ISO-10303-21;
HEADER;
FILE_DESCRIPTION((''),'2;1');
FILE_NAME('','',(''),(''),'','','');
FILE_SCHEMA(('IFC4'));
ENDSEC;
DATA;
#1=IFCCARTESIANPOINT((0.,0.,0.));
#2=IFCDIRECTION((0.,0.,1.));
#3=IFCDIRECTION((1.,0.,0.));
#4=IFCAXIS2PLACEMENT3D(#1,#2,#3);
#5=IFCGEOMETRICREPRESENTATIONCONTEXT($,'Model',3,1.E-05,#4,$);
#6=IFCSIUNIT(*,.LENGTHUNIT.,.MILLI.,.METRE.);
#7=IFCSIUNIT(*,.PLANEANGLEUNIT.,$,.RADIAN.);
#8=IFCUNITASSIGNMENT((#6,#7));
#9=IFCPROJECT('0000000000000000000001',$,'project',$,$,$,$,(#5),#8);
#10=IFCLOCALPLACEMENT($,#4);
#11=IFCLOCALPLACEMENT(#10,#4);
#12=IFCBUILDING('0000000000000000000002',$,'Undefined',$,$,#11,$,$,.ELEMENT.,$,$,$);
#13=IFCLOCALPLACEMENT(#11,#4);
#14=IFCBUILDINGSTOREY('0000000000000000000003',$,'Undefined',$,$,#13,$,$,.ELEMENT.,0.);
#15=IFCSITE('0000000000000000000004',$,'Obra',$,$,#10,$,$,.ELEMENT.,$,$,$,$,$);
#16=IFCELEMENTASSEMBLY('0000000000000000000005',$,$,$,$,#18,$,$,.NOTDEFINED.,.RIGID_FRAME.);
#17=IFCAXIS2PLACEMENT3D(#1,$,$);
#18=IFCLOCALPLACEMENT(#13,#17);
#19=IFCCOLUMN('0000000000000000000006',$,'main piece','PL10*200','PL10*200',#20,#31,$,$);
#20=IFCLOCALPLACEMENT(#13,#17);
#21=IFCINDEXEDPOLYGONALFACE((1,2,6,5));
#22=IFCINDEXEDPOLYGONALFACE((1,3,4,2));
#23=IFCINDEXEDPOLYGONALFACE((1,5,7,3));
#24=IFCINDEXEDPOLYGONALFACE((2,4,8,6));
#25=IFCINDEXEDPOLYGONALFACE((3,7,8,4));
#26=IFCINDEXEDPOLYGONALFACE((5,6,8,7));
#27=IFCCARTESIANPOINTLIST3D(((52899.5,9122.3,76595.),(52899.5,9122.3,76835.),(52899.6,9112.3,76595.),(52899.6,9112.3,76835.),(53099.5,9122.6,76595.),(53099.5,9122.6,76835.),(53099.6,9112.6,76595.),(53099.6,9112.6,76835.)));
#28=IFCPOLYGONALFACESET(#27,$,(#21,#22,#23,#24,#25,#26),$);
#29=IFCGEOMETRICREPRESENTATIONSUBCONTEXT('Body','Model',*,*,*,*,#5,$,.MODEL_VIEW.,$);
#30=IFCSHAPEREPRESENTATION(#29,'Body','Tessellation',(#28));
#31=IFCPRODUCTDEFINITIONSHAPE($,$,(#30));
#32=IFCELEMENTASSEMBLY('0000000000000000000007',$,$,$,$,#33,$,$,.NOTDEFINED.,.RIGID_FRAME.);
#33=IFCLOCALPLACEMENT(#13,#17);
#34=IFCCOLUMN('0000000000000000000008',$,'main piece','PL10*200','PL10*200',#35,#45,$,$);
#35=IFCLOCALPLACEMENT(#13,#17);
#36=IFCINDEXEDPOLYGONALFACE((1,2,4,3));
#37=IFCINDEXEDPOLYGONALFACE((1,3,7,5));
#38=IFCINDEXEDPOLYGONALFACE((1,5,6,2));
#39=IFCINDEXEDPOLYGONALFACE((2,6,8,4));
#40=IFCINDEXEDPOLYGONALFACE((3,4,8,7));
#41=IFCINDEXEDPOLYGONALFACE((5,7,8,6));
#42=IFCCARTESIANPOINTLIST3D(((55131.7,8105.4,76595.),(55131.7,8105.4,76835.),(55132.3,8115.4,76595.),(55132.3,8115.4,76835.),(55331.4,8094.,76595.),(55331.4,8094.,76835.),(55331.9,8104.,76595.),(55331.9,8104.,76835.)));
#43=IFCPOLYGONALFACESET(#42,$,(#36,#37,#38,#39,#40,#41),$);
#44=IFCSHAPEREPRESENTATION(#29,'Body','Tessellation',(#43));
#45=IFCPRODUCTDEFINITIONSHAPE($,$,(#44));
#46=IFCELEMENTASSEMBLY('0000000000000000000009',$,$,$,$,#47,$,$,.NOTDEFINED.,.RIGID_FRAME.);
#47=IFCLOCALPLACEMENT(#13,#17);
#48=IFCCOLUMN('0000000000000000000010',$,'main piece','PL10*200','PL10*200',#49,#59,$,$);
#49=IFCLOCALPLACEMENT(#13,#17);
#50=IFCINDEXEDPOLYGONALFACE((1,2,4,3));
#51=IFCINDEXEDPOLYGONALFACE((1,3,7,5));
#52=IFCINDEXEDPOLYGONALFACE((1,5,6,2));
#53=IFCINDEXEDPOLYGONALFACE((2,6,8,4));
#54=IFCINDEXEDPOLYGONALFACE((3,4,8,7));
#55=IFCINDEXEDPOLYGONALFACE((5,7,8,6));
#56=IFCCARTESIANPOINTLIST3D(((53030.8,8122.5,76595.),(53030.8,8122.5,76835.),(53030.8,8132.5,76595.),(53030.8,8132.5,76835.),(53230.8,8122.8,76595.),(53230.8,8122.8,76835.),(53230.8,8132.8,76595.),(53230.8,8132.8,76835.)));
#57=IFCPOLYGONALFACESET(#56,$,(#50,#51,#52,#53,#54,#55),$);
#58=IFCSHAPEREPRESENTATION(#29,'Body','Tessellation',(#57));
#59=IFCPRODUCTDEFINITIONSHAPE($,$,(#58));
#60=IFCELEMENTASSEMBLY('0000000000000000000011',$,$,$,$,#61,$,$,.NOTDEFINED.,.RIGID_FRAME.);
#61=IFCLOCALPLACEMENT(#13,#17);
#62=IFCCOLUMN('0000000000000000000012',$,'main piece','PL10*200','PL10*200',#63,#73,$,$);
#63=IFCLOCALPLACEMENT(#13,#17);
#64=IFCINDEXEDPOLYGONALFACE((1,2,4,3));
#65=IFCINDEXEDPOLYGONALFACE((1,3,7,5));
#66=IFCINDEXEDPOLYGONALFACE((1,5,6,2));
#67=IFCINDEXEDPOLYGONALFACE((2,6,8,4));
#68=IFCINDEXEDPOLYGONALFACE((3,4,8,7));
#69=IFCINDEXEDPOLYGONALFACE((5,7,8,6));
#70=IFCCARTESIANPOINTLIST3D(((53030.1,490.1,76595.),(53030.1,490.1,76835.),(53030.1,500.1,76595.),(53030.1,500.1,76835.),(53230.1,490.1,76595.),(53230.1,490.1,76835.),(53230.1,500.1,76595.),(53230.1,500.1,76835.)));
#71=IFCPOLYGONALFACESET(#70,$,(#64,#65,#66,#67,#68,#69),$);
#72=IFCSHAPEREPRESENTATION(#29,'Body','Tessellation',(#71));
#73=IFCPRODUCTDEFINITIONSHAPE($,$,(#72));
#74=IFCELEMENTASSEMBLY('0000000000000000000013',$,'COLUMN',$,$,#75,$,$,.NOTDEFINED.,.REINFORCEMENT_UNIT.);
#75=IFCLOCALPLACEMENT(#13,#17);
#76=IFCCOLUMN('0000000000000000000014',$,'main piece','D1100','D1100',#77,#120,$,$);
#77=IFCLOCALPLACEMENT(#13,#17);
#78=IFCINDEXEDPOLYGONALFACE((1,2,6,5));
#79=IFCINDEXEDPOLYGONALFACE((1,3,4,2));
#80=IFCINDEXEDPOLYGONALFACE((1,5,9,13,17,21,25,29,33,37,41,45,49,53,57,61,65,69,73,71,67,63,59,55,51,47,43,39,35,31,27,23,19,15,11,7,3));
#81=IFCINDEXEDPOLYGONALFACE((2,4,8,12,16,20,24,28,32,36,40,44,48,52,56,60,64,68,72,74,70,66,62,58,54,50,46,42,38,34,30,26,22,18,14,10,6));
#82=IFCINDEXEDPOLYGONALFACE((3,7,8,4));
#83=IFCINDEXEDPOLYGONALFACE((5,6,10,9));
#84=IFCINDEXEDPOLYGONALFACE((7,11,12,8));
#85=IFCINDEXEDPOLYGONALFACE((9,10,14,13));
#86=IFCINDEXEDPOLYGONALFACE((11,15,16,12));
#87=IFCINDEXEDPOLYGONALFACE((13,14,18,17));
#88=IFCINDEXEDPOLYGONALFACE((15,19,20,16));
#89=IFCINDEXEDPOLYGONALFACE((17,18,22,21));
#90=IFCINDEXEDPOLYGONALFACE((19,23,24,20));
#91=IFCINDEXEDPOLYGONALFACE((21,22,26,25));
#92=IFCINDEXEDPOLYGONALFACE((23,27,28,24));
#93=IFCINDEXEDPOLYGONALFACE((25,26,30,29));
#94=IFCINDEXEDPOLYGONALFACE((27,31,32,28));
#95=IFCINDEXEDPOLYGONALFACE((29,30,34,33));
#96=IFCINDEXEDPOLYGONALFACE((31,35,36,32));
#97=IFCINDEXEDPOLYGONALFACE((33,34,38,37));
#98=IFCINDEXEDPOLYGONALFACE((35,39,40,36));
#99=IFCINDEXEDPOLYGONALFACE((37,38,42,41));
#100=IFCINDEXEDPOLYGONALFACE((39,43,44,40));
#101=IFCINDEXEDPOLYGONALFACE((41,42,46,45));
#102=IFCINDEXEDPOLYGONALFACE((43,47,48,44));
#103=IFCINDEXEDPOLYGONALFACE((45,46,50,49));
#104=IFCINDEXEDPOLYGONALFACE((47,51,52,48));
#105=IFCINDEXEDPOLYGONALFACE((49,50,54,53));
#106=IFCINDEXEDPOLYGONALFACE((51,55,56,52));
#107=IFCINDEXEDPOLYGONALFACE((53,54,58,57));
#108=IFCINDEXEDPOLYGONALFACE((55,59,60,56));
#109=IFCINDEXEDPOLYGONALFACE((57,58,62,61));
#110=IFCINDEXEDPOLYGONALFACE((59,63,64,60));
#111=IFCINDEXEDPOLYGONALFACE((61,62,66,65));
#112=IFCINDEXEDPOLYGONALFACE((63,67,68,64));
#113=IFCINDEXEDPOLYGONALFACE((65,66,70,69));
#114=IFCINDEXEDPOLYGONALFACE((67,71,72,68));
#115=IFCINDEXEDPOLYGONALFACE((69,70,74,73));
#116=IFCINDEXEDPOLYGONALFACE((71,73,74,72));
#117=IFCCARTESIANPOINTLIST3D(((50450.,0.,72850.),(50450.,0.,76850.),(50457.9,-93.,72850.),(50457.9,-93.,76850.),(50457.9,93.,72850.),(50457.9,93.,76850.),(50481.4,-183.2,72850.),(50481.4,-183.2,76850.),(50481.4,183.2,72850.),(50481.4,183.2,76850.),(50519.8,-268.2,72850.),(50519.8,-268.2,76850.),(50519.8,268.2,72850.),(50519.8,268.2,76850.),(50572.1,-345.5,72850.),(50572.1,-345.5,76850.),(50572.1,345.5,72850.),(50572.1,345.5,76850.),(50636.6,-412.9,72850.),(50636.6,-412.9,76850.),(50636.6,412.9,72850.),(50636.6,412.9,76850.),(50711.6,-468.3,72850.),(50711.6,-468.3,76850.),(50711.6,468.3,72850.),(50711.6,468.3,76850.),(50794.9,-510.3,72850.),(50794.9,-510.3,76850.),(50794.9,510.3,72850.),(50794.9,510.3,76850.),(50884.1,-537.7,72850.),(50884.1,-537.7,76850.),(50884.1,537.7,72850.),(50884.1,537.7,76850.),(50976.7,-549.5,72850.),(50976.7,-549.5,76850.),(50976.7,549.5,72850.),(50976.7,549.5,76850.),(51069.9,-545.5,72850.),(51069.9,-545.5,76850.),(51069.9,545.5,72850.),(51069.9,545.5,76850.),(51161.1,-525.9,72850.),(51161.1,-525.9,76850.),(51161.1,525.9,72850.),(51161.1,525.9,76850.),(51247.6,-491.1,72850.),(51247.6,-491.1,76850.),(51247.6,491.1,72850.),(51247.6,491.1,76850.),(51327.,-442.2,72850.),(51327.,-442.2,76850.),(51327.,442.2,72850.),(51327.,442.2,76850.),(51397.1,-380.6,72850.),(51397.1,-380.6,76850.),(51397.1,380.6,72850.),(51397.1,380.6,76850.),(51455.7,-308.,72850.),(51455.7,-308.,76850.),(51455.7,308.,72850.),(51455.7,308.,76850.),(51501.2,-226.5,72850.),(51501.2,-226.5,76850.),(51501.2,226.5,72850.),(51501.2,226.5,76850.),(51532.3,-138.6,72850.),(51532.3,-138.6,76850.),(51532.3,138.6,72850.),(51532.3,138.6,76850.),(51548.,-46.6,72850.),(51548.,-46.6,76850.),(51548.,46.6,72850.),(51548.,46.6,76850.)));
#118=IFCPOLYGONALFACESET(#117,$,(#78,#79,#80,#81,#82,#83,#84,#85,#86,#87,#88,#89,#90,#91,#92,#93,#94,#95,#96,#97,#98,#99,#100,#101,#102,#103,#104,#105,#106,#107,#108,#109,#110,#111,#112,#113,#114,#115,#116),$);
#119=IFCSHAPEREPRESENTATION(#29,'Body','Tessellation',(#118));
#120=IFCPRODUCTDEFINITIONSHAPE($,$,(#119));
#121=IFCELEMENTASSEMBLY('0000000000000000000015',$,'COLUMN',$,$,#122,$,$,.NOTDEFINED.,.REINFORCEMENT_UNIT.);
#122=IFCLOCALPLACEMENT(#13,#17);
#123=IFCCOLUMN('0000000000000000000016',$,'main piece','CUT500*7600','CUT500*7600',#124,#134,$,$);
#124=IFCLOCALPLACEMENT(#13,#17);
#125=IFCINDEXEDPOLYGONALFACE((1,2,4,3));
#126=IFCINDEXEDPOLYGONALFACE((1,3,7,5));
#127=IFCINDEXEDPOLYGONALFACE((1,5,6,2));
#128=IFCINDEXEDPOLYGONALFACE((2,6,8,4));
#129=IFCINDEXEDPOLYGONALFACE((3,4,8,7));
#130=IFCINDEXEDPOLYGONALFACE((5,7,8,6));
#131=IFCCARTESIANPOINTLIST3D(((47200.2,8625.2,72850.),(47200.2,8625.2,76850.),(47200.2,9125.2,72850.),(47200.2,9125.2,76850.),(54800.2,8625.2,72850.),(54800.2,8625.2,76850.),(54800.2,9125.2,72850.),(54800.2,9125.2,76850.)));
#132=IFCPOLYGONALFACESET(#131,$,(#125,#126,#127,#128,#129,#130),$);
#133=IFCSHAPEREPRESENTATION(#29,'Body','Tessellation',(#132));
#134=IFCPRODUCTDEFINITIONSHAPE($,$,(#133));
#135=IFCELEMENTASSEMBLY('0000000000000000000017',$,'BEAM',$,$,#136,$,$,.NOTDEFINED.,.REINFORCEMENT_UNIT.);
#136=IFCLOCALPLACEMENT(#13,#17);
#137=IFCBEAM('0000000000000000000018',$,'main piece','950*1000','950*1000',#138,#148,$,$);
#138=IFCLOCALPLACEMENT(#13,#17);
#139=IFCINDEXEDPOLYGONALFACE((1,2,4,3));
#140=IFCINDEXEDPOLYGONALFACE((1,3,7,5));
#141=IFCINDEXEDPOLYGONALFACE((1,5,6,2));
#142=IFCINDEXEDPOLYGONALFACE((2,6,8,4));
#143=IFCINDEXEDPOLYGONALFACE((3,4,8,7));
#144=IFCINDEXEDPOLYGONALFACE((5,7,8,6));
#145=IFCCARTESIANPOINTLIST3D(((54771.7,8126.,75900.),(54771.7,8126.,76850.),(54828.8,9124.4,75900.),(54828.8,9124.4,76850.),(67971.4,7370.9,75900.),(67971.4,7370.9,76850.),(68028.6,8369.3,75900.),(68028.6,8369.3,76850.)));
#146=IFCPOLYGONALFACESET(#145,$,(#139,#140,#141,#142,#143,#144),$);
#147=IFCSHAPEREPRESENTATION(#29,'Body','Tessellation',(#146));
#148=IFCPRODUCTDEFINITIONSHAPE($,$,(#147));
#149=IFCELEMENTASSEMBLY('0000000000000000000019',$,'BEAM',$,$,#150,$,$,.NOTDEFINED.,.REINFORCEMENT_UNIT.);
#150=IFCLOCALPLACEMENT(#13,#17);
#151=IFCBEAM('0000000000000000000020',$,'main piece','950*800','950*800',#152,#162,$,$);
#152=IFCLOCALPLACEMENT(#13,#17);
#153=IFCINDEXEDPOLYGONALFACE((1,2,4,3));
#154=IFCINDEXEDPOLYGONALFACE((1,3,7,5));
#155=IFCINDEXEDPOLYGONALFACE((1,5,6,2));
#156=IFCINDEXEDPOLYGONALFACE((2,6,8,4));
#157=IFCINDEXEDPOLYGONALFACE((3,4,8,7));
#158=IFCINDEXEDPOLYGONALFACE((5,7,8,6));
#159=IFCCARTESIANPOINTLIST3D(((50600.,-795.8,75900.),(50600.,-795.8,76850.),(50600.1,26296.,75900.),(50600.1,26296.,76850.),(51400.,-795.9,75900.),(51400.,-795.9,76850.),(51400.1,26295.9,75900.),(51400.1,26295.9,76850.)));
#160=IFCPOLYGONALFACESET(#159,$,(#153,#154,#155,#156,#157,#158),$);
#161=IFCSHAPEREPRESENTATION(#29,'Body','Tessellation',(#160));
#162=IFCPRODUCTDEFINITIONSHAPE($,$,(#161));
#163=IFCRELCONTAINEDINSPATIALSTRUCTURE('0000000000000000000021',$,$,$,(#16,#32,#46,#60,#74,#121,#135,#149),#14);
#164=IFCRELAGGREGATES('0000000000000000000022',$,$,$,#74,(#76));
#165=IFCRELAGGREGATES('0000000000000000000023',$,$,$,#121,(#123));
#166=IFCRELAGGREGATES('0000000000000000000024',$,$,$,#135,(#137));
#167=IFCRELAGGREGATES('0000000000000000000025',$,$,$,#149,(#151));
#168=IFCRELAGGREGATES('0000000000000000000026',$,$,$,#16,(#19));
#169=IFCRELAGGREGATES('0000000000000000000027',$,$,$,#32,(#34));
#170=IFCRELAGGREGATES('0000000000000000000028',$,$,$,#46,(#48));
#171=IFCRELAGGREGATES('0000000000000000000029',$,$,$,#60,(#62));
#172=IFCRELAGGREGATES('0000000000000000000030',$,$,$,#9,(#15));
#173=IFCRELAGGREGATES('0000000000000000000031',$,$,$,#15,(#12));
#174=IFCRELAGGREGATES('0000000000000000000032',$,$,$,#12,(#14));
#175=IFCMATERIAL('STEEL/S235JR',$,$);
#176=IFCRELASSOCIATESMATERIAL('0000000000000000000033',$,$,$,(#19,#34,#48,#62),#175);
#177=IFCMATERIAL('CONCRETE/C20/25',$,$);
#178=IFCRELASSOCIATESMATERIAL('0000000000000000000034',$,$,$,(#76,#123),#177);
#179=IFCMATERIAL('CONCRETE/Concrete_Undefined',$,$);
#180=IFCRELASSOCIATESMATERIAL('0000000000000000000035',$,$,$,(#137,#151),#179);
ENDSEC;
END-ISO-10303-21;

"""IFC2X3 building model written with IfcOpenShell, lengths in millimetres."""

from ifc_helpers import new_model, si_unit, frame, origin_with_axes, origin_2d_with_axis, place, context, subcontext, project, spatial, rectangle, circle, extrude, material, element, aggregate, save


model = new_model("IFC2X3")

# Units and contexts
model_context = context("Model", 3, precision=1e-05, world=origin_with_axes())
body_context = subcontext(model_context, "Body", "Model", "MODEL_VIEW")
ifc_project = project(units=[si_unit("LENGTHUNIT", "METRE", prefix="MILLI"), si_unit("PLANEANGLEUNIT", "RADIAN")], contexts=[model_context])

# Site, building, storey
site_placement = place(None, origin_with_axes())
site = spatial("IfcSite", under=ifc_project, at=site_placement, Name="Obra", CompositionType="ELEMENT")
building_placement = place(site_placement, origin_with_axes())
building = spatial("IfcBuilding", under=site, at=building_placement, Name="Undefined", CompositionType="ELEMENT")
storey_placement = place(building_placement, origin_with_axes())
storey = spatial("IfcBuildingStorey", under=building, at=storey_placement, Name="Undefined", CompositionType="ELEMENT", Elevation=0.0)

# Element assemblies, columns
assembly_1_placement = place(storey_placement, origin_with_axes())
assembly_1 = element("IfcElementAssembly", 1, at=assembly_1_placement, inside=storey, AssemblyPlace="NOTDEFINED", PredefinedType="RIGID_FRAME")
ifc_material_1 = material(Name="STEEL/S235JR")
column_1_placement = place(assembly_1_placement, frame((52999.6, 9117.5, 76595.0), z_axis=(0.0, 0.0, 1.0), x_axis=(0.999999, 0.001508, 0.0)))
column_1 = element("IfcColumn", 2, at=column_1_placement, material=ifc_material_1, Name="main piece", Description="PL10*200", ObjectType="PL10*200", context=body_context, shape_type="SweptSolid", body=[
    extrude(rectangle(XDim=10.0, YDim=200.0, at=origin_2d_with_axis()), frame((0.0, 0.0, 240.0), z_axis=(0.0, 0.0, -1.0), x_axis=(0.0, 1.0, 0.0)), (0.0, 0.0, 1.0), 240.0),
])
assembly_2_placement = place(storey_placement, origin_with_axes())
assembly_2 = element("IfcElementAssembly", 3, at=assembly_2_placement, inside=storey, AssemblyPlace="NOTDEFINED", PredefinedType="RIGID_FRAME")
column_2_placement = place(assembly_2_placement, frame((55231.8, 8104.7, 76595.0), z_axis=(0.0, 0.0, 1.0), x_axis=(-0.998368, 0.05711, 0.0)))
column_2 = element("IfcColumn", 4, at=column_2_placement, material=ifc_material_1, Name="main piece", Description="PL10*200", ObjectType="PL10*200", context=body_context, shape_type="SweptSolid", body=[
    extrude(rectangle(XDim=10.0, YDim=200.0, at=origin_2d_with_axis()), frame((0.0, 0.0, 240.0), z_axis=(0.0, 0.0, -1.0), x_axis=(0.0, 1.0, 0.0)), (0.0, 0.0, 1.0), 240.0),
])
assembly_3_placement = place(storey_placement, origin_with_axes())
assembly_3 = element("IfcElementAssembly", 5, at=assembly_3_placement, inside=storey, AssemblyPlace="NOTDEFINED", PredefinedType="RIGID_FRAME")
column_3_placement = place(assembly_3_placement, frame((53130.8, 8127.7, 76595.0), z_axis=(0.0, 0.0, 1.0), x_axis=(-0.999999, -0.001508, 0.0)))
column_3 = element("IfcColumn", 6, at=column_3_placement, material=ifc_material_1, Name="main piece", Description="PL10*200", ObjectType="PL10*200", context=body_context, shape_type="SweptSolid", body=[
    extrude(rectangle(XDim=10.0, YDim=200.0, at=origin_2d_with_axis()), frame((0.0, 0.0, 240.0), z_axis=(0.0, 0.0, -1.0), x_axis=(0.0, 1.0, 0.0)), (0.0, 0.0, 1.0), 240.0),
])
assembly_4_placement = place(storey_placement, origin_with_axes())
assembly_4 = element("IfcElementAssembly", 7, at=assembly_4_placement, inside=storey, AssemblyPlace="NOTDEFINED", PredefinedType="RIGID_FRAME")
column_4_placement = place(assembly_4_placement, frame((53130.1, 495.1, 76595.0), z_axis=(0.0, 0.0, 1.0), x_axis=(1.0, 0.000002, 0.0)))
column_4 = element("IfcColumn", 8, at=column_4_placement, material=ifc_material_1, Name="main piece", Description="PL10*200", ObjectType="PL10*200", context=body_context, shape_type="SweptSolid", body=[
    extrude(rectangle(XDim=10.0, YDim=200.0, at=origin_2d_with_axis()), frame((0.0, 0.0, 240.0), z_axis=(0.0, 0.0, -1.0), x_axis=(0.0, 1.0, 0.0)), (0.0, 0.0, 1.0), 240.0),
])
assembly_5_placement = place(storey_placement, origin_with_axes())
assembly_5 = element("IfcElementAssembly", 9, at=assembly_5_placement, inside=storey, Name="COLUMN", AssemblyPlace="NOTDEFINED", PredefinedType="REINFORCEMENT_UNIT")
ifc_material_2 = material(Name="CONCRETE/C20/25")
column_5_placement = place(assembly_5_placement, frame((51000.0, 0.0, 72850.0), z_axis=(0.0, 0.0, 1.0), x_axis=(0.0, 1.0, 0.0)))
column_5 = element("IfcColumn", 10, at=column_5_placement, material=ifc_material_2, Name="main piece", Description="D1100", ObjectType="D1100", context=body_context, shape_type="SweptSolid", body=[
    extrude(circle(Radius=550.0, at=origin_2d_with_axis()), frame((0.0, 0.0, 4000.0), z_axis=(0.0, 0.0, -1.0), x_axis=(0.0, 1.0, 0.0)), (0.0, 0.0, 1.0), 4000.0),
])
aggregate(assembly_5, [column_5])
assembly_6_placement = place(storey_placement, origin_with_axes())
assembly_6 = element("IfcElementAssembly", 11, at=assembly_6_placement, inside=storey, Name="COLUMN", AssemblyPlace="NOTDEFINED", PredefinedType="REINFORCEMENT_UNIT")
column_6_placement = place(assembly_6_placement, frame((51000.2, 8875.2, 72850.0), z_axis=(0.0, 0.0, 1.0), x_axis=(-1.0, 0.0, 0.0)))
column_6 = element("IfcColumn", 12, at=column_6_placement, material=ifc_material_2, Name="main piece", Description="CUT500*7600", ObjectType="CUT500*7600", context=body_context, shape_type="SweptSolid", body=[
    extrude(rectangle(XDim=500.0, YDim=7600.0, at=origin_2d_with_axis()), frame((0.0, 0.0, 4000.0), z_axis=(0.0, 0.0, -1.0), x_axis=(0.0, 1.0, 0.0)), (0.0, 0.0, 1.0), 4000.0),
])
aggregate(assembly_6, [column_6])

# Element assemblies, beams
assembly_7_placement = place(storey_placement, origin_with_axes())
assembly_7 = element("IfcElementAssembly", 13, at=assembly_7_placement, inside=storey, Name="BEAM", AssemblyPlace="NOTDEFINED", PredefinedType="REINFORCEMENT_UNIT")
ifc_material_3 = material(Name="CONCRETE/Concrete_Undefined")
beam_1_placement = place(assembly_7_placement, frame((54800.2, 8625.2, 76375.0), z_axis=(0.0, 0.0, 1.0), x_axis=(0.998368, -0.05711, 0.0)))
beam_1 = element("IfcBeam", 14, at=beam_1_placement, material=ifc_material_3, Name="main piece", Description="950*1000", ObjectType="950*1000", context=body_context, shape_type="SweptSolid", body=[
    extrude(rectangle(XDim=1000.0, YDim=950.0, at=origin_2d_with_axis()), frame((13221.4, 0.0, 0.0), z_axis=(-1.0, 0.0, 0.0), x_axis=(0.0, -1.0, 0.0)), (0.0, 0.0, 1.0), 13221.4),
])
aggregate(assembly_7, [beam_1])
assembly_8_placement = place(storey_placement, origin_with_axes())
assembly_8 = element("IfcElementAssembly", 15, at=assembly_8_placement, inside=storey, Name="BEAM", AssemblyPlace="NOTDEFINED", PredefinedType="REINFORCEMENT_UNIT")
beam_2_placement = place(assembly_8_placement, frame((51000.0, -795.8, 76375.0), z_axis=(0.0, 0.0, 1.0), x_axis=(0.000003, 1.0, 0.0)))
beam_2 = element("IfcBeam", 16, at=beam_2_placement, material=ifc_material_3, Name="main piece", Description="950*800", ObjectType="950*800", context=body_context, shape_type="SweptSolid", body=[
    extrude(rectangle(XDim=800.0, YDim=950.0, at=origin_2d_with_axis()), frame((27091.8, 0.0, 0.0), z_axis=(-1.0, 0.0, 0.0), x_axis=(0.0, -1.0, 0.0)), (0.0, 0.0, 1.0), 27091.8),
])
aggregate(assembly_8, [beam_2])

aggregate(assembly_1, [column_1])
aggregate(assembly_2, [column_2])
aggregate(assembly_3, [column_3])
aggregate(assembly_4, [column_4])

save(model, "model.ifc")
